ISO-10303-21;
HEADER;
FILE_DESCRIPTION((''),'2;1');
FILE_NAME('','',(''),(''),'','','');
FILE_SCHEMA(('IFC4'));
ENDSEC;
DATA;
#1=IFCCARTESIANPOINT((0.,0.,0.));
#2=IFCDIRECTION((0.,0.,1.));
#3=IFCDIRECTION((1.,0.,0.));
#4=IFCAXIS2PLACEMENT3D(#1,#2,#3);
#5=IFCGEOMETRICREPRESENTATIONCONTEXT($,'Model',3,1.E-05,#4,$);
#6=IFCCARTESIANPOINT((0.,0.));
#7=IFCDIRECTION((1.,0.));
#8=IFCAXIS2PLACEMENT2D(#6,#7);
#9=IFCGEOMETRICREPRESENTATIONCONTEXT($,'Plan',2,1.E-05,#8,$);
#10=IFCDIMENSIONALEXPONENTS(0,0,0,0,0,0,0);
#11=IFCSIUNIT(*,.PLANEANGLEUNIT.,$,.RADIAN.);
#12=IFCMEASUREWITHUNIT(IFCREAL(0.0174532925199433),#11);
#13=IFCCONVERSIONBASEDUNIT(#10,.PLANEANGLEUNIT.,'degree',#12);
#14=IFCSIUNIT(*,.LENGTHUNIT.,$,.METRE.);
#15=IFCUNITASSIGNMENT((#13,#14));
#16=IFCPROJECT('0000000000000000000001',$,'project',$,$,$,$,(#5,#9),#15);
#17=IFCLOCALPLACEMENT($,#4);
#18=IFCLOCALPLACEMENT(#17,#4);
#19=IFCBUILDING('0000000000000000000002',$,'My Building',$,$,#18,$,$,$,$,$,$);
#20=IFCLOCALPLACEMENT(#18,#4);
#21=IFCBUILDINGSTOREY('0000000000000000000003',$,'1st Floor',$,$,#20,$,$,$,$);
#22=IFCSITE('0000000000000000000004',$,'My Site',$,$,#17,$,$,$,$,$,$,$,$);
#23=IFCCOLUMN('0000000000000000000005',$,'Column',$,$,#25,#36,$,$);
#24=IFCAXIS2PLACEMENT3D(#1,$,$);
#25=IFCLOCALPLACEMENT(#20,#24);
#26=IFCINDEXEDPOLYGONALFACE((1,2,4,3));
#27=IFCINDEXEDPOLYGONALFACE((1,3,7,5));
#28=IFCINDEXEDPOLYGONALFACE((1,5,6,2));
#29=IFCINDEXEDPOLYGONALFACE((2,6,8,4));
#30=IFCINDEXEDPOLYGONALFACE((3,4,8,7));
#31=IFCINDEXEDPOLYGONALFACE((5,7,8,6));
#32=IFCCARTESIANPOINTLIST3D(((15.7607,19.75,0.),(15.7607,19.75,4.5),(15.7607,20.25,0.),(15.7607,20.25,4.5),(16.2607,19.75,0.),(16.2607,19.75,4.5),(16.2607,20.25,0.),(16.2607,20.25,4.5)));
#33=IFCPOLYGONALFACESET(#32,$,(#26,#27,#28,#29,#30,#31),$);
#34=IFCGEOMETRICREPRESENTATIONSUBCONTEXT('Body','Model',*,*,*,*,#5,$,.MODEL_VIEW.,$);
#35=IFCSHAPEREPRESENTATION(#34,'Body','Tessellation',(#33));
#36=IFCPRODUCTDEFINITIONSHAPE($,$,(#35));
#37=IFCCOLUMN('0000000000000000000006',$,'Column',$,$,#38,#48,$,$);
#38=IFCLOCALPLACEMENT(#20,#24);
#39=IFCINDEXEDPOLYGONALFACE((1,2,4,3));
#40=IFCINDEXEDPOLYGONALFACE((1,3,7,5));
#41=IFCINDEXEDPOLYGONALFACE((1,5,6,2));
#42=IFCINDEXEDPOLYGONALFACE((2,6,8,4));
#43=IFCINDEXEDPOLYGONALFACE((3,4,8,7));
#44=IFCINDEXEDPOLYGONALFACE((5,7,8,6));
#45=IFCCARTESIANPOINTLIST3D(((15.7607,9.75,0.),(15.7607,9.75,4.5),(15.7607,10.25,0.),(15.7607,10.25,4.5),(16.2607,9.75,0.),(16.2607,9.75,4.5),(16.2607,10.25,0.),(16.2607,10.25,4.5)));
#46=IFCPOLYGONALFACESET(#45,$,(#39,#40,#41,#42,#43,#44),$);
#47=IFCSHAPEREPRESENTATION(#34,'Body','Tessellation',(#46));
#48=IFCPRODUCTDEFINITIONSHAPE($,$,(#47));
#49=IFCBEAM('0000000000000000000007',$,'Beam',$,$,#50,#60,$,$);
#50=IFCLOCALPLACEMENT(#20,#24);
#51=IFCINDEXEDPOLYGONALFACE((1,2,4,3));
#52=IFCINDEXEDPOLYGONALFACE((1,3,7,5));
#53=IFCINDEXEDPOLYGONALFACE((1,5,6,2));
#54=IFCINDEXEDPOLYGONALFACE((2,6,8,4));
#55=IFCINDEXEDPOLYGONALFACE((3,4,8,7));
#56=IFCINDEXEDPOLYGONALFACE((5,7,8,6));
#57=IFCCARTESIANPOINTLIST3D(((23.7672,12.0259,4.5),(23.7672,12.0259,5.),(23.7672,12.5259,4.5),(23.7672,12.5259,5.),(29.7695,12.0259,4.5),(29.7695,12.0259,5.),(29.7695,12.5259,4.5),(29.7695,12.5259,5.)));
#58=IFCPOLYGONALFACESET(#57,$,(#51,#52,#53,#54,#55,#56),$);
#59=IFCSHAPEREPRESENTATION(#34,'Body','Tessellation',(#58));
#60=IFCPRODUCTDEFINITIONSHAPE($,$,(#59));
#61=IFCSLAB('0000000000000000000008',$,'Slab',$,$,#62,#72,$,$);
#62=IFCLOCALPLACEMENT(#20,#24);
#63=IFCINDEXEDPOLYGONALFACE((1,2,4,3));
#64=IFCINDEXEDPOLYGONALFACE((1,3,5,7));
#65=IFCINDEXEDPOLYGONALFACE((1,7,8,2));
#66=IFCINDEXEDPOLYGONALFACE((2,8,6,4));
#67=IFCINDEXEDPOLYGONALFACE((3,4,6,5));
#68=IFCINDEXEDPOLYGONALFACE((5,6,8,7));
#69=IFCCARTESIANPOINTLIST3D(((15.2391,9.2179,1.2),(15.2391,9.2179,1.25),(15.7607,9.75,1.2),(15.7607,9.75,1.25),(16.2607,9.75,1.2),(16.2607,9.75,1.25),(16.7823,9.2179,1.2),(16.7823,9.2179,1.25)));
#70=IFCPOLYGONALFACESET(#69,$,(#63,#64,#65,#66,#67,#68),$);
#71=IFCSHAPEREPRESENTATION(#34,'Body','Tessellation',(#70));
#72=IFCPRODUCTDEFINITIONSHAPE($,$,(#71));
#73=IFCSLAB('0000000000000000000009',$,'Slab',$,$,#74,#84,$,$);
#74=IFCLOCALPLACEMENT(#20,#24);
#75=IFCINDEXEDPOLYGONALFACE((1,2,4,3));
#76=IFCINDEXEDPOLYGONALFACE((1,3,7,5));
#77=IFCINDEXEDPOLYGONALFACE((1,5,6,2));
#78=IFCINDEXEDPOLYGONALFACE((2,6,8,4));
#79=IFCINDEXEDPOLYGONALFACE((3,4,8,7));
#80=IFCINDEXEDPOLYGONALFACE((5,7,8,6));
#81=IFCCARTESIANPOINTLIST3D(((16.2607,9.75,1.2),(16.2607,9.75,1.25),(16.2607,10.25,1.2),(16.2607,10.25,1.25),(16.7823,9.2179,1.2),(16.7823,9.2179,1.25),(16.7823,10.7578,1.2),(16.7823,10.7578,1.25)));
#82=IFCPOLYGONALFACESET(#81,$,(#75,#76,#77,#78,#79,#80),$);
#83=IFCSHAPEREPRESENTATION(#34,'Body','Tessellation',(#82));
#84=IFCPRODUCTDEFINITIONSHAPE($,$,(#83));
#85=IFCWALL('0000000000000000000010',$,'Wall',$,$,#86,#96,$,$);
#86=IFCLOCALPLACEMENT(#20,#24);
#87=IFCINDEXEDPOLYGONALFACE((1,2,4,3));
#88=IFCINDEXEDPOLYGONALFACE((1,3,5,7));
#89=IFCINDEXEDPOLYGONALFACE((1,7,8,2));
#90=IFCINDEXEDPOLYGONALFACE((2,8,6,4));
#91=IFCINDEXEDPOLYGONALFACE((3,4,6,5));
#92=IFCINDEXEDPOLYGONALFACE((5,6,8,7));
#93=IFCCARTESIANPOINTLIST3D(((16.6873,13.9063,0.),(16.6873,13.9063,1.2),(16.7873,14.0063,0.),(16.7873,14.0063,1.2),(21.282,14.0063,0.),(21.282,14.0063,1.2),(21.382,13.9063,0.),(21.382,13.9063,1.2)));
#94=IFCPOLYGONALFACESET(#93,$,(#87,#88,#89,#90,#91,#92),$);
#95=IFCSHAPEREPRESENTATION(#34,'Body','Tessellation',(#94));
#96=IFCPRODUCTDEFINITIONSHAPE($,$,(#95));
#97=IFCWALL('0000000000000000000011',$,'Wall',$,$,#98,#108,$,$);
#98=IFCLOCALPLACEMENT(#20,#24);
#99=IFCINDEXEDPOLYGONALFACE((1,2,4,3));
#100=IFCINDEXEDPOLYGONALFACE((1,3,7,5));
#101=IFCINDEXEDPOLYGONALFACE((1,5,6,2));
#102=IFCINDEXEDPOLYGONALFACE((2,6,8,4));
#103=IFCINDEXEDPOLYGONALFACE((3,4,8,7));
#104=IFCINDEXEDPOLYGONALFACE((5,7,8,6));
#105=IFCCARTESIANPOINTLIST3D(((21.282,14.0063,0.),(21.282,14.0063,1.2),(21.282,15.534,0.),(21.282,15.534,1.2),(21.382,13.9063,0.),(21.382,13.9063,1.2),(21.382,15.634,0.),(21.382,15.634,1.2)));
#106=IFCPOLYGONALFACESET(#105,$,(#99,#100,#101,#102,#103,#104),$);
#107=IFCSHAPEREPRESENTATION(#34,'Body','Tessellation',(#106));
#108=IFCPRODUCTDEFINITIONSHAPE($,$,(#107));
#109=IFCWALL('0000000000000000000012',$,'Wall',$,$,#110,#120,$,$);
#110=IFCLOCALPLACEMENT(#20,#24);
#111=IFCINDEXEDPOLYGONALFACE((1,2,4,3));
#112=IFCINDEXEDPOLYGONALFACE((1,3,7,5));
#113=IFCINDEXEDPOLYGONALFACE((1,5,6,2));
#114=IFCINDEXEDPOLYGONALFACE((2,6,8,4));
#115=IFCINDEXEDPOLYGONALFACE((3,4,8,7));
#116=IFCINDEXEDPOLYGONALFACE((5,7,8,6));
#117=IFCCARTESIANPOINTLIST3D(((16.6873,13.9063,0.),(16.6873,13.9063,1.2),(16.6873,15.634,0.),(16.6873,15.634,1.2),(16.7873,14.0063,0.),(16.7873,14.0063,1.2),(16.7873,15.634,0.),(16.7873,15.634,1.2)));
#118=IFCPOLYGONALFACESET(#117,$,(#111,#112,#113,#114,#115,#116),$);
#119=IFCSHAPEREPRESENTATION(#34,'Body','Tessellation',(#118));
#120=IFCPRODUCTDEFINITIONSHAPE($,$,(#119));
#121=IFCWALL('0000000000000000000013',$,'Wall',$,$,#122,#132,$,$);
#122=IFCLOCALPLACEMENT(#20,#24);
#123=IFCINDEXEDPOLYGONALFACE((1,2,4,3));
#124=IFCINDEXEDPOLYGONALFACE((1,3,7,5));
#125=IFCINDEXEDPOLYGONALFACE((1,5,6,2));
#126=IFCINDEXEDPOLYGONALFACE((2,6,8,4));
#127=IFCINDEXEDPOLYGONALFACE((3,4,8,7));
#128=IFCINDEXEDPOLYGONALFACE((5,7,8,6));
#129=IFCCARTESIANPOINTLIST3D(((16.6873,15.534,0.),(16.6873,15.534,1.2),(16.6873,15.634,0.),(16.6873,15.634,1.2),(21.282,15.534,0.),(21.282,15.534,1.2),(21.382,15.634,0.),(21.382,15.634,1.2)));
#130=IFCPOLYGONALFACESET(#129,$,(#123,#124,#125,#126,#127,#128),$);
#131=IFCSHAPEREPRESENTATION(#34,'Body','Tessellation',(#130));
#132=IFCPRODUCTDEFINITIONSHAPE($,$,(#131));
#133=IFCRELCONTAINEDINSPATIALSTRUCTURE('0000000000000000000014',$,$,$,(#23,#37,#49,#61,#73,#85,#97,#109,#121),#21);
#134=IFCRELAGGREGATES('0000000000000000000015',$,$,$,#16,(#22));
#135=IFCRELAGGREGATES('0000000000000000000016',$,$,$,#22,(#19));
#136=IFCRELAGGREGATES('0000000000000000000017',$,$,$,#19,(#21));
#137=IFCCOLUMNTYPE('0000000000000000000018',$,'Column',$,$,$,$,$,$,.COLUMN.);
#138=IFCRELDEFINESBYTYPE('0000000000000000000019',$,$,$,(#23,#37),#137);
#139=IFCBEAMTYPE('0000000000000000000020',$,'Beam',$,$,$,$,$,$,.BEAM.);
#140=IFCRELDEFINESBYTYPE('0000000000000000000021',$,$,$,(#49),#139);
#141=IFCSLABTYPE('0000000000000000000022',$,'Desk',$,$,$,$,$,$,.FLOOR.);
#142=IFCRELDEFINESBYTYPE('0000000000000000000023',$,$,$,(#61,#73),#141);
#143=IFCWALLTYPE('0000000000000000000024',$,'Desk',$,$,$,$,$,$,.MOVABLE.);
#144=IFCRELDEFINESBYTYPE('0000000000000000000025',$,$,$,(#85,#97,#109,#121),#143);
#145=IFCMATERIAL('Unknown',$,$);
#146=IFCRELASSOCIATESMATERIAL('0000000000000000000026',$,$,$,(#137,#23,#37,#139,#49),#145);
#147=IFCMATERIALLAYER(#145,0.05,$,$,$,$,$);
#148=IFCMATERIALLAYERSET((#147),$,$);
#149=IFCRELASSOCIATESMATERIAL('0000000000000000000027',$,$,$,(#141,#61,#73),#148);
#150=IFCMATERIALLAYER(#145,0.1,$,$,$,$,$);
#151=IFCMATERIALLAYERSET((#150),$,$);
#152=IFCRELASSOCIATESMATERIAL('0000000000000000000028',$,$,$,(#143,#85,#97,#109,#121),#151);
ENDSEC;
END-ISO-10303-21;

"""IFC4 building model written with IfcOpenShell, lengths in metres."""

from ifc_helpers import new_model, entity, si_unit, converted_unit, frame, origin_with_axes, origin_2d_with_axis, place, context, subcontext, project, spatial, line, indexed_curve, rectangle, outline, extrude, material, layer, layer_set, layer_usage, material_profile, profile_set, profile_usage, type_object, element, save


model = new_model("IFC4")

# Units and contexts
model_context = context("Model", 3, precision=1e-05, world=origin_with_axes())
plan_context = context("Plan", 2, precision=1e-05, world=origin_2d_with_axis())
body_context = subcontext(model_context, "Body", "Model", "MODEL_VIEW")
ifc_project = project(units=[converted_unit("PLANEANGLEUNIT", "degree", entity("IfcReal", 0.0174532925199433), si_unit("PLANEANGLEUNIT", "RADIAN"), dimensions=[0, 0, 0, 0, 0, 0, 0]), si_unit("LENGTHUNIT", "METRE")], contexts=[model_context, plan_context])

# Site, building, storey
site_placement = place(None, origin_with_axes())
site = spatial("IfcSite", under=ifc_project, at=site_placement, Name="My Site")
building_placement = place(site_placement, origin_with_axes())
building = spatial("IfcBuilding", under=site, at=building_placement, Name="My Building")
storey_placement = place(building_placement, origin_with_axes())
storey = spatial("IfcBuildingStorey", under=building, at=storey_placement, Name="1st Floor")

# Columns
ifc_material = material(Name="Unknown")
ifc_material_profile_1 = material_profile(ifc_material, rectangle(XDim=0.5, YDim=0.5))
ifc_profile_set_1 = profile_set([ifc_material_profile_1])
ifc_profile_usage_1 = profile_usage(ifc_profile_set_1, cardinal=5)
column_type = type_object("IfcColumnType", Name="Column", PredefinedType="COLUMN", material=ifc_profile_set_1)
column_1_placement = place(storey_placement, frame((16.0107, 20.0, 0.0), z_axis=(0.0, 0.0, 1.0), x_axis=(1.0, 0.0, 0.0)))
element("IfcColumn", 1, at=column_1_placement, inside=storey, type_object=column_type, material=ifc_profile_usage_1, Name="Column", context=body_context, shape_type="SweptSolid", body=[
    extrude(rectangle(XDim=0.5, YDim=0.5), origin_with_axes(), (0.0, 0.0, 1.0), 4.5),
])
ifc_profile_usage_2 = profile_usage(ifc_profile_set_1, cardinal=5)
column_2_placement = place(storey_placement, frame((16.0107, 10.0, 0.0), z_axis=(0.0, 0.0, 1.0), x_axis=(1.0, 0.0, 0.0)))
element("IfcColumn", 2, at=column_2_placement, inside=storey, type_object=column_type, material=ifc_profile_usage_2, Name="Column", context=body_context, shape_type="SweptSolid", body=[
    extrude(rectangle(XDim=0.5, YDim=0.5), origin_with_axes(), (0.0, 0.0, 1.0), 4.5),
])

# Beam
ifc_material_profile_2 = material_profile(ifc_material, rectangle(XDim=0.5, YDim=0.5))
ifc_profile_set_2 = profile_set([ifc_material_profile_2])
ifc_profile_usage_3 = profile_usage(ifc_profile_set_2, cardinal=2)
beam_type = type_object("IfcBeamType", Name="Beam", PredefinedType="BEAM", material=ifc_profile_set_2)
beam_placement = place(storey_placement, frame((23.7672, 12.2759, 4.5), z_axis=(1.0, 0.0, 0.0), x_axis=(0.0, 1.0, 0.0)))
element("IfcBeam", 3, at=beam_placement, inside=storey, type_object=beam_type, material=ifc_profile_usage_3, Name="Beam", context=body_context, shape_type="SweptSolid", body=[
    extrude(rectangle(XDim=0.5, YDim=0.5), frame((0.0, 0.25, 0.0), z_axis=(0.0, 0.0, 1.0), x_axis=(1.0, 0.0, 0.0)), (0.0, 0.0, 1.0), 6.0023),
])

# Slabs
ifc_layer_1 = layer(ifc_material, 0.05)
ifc_layer_set_1 = layer_set([ifc_layer_1])
ifc_layer_usage_1 = layer_usage(ifc_layer_set_1, "AXIS3", "POSITIVE", -0.05)
slab_type = type_object("IfcSlabType", Name="Desk", PredefinedType="FLOOR", material=ifc_layer_set_1)
slab_1_placement = place(storey_placement, frame((16.7823, 9.2179, 1.25), z_axis=(0.0, 0.0, 1.0), x_axis=(1.0, 0.0, 0.0)))
element("IfcSlab", 4, at=slab_1_placement, inside=storey, type_object=slab_type, material=ifc_layer_usage_1, Name="Slab", context=body_context, shape_type="SweptSolid", body=[
    extrude(outline(indexed_curve([(0.0, 0.0), (-0.5216, 0.5321), (-1.0216, 0.5321), (-1.5432, 0.0), (0.0, 0.0)])), frame((0.0, 0.0, -0.05), z_axis=(0.0, 0.0, 1.0), x_axis=(1.0, 0.0, 0.0)), (0.0, 0.0, 1.0), 0.05),
])
ifc_layer_usage_2 = layer_usage(ifc_layer_set_1, "AXIS3", "POSITIVE", -0.05)
slab_2_placement = place(storey_placement, frame((16.7823, 10.7578, 1.25), z_axis=(0.0, 0.0, 1.0), x_axis=(1.0, 0.0, 0.0)))
element("IfcSlab", 5, at=slab_2_placement, inside=storey, type_object=slab_type, material=ifc_layer_usage_2, Name="Slab", context=body_context, shape_type="SweptSolid", body=[
    extrude(outline(indexed_curve([(0.0, 0.0), (-0.5216, -0.5078), (-0.5216, -1.0078), (0.0, -1.5399), (0.0, 0.0)])), frame((0.0, 0.0, -0.05), z_axis=(0.0, 0.0, 1.0), x_axis=(1.0, 0.0, 0.0)), (0.0, 0.0, 1.0), 0.05),
])

# Walls
ifc_layer_2 = layer(ifc_material, 0.1)
ifc_layer_set_2 = layer_set([ifc_layer_2])
ifc_layer_usage_3 = layer_usage(ifc_layer_set_2, "AXIS2", "POSITIVE", 0.0)
wall_type = type_object("IfcWallType", Name="Desk", PredefinedType="MOVABLE", material=ifc_layer_set_2)
wall_1_placement = place(storey_placement, frame((16.6873, 13.9063, 0.0), z_axis=(0.0, 0.0, 1.0), x_axis=(1.0, 0.000001, 0.0)))
element("IfcWall", 6, at=wall_1_placement, inside=storey, type_object=wall_type, material=ifc_layer_usage_3, Name="Wall", context=body_context, shape_type="SweptSolid", body=[
    extrude(outline(indexed_curve([(0.0, 0.0), (0.1, 0.1), (4.5947, 0.1), (4.6947, 0.0)], segments=[line(1, 2, 3, 4, 1)])), origin_with_axes(), (0.0, 0.0, 1.0), 1.2),
])
ifc_layer_usage_4 = layer_usage(ifc_layer_set_2, "AXIS2", "POSITIVE", 0.0)
wall_2_placement = place(storey_placement, frame((21.382, 13.9063, 0.0), z_axis=(0.0, 0.0, 1.0), x_axis=(0.0, 1.0, 0.0)))
element("IfcWall", 7, at=wall_2_placement, inside=storey, type_object=wall_type, material=ifc_layer_usage_4, Name="Wall", context=body_context, shape_type="SweptSolid", body=[
    extrude(outline(indexed_curve([(0.0, 0.0), (0.1, 0.1), (1.6277, 0.1), (1.7277, 0.0)], segments=[line(1, 2, 3, 4, 1)])), origin_with_axes(), (0.0, 0.0, 1.0), 1.2),
])
ifc_layer_usage_5 = layer_usage(ifc_layer_set_2, "AXIS2", "POSITIVE", 0.0)
wall_3_placement = place(storey_placement, frame((16.6873, 15.634, 0.0), z_axis=(0.0, 0.0, 1.0), x_axis=(0.000001, -1.0, 0.0)))
element("IfcWall", 8, at=wall_3_placement, inside=storey, type_object=wall_type, material=ifc_layer_usage_5, Name="Wall", context=body_context, shape_type="SweptSolid", body=[
    extrude(outline(indexed_curve([(0.0, 0.0), (0.0, 0.1), (1.6277, 0.1), (1.7277, 0.0)], segments=[line(1, 2, 3, 4, 1)])), origin_with_axes(), (0.0, 0.0, 1.0), 1.2),
])
ifc_layer_usage_6 = layer_usage(ifc_layer_set_2, "AXIS2", "POSITIVE", 0.0)
wall_4_placement = place(storey_placement, frame((21.382, 15.634, 0.0), z_axis=(0.0, 0.0, 1.0), x_axis=(-1.0, -0.000001, 0.0)))
element("IfcWall", 9, at=wall_4_placement, inside=storey, type_object=wall_type, material=ifc_layer_usage_6, Name="Wall", context=body_context, shape_type="SweptSolid", body=[
    extrude(outline(indexed_curve([(0.0, 0.0), (0.1, 0.1), (4.6947, 0.1), (4.6947, 0.0)], segments=[line(1, 2, 3, 4, 1)])), origin_with_axes(), (0.0, 0.0, 1.0), 1.2),
])

save(model, "model.ifc")
